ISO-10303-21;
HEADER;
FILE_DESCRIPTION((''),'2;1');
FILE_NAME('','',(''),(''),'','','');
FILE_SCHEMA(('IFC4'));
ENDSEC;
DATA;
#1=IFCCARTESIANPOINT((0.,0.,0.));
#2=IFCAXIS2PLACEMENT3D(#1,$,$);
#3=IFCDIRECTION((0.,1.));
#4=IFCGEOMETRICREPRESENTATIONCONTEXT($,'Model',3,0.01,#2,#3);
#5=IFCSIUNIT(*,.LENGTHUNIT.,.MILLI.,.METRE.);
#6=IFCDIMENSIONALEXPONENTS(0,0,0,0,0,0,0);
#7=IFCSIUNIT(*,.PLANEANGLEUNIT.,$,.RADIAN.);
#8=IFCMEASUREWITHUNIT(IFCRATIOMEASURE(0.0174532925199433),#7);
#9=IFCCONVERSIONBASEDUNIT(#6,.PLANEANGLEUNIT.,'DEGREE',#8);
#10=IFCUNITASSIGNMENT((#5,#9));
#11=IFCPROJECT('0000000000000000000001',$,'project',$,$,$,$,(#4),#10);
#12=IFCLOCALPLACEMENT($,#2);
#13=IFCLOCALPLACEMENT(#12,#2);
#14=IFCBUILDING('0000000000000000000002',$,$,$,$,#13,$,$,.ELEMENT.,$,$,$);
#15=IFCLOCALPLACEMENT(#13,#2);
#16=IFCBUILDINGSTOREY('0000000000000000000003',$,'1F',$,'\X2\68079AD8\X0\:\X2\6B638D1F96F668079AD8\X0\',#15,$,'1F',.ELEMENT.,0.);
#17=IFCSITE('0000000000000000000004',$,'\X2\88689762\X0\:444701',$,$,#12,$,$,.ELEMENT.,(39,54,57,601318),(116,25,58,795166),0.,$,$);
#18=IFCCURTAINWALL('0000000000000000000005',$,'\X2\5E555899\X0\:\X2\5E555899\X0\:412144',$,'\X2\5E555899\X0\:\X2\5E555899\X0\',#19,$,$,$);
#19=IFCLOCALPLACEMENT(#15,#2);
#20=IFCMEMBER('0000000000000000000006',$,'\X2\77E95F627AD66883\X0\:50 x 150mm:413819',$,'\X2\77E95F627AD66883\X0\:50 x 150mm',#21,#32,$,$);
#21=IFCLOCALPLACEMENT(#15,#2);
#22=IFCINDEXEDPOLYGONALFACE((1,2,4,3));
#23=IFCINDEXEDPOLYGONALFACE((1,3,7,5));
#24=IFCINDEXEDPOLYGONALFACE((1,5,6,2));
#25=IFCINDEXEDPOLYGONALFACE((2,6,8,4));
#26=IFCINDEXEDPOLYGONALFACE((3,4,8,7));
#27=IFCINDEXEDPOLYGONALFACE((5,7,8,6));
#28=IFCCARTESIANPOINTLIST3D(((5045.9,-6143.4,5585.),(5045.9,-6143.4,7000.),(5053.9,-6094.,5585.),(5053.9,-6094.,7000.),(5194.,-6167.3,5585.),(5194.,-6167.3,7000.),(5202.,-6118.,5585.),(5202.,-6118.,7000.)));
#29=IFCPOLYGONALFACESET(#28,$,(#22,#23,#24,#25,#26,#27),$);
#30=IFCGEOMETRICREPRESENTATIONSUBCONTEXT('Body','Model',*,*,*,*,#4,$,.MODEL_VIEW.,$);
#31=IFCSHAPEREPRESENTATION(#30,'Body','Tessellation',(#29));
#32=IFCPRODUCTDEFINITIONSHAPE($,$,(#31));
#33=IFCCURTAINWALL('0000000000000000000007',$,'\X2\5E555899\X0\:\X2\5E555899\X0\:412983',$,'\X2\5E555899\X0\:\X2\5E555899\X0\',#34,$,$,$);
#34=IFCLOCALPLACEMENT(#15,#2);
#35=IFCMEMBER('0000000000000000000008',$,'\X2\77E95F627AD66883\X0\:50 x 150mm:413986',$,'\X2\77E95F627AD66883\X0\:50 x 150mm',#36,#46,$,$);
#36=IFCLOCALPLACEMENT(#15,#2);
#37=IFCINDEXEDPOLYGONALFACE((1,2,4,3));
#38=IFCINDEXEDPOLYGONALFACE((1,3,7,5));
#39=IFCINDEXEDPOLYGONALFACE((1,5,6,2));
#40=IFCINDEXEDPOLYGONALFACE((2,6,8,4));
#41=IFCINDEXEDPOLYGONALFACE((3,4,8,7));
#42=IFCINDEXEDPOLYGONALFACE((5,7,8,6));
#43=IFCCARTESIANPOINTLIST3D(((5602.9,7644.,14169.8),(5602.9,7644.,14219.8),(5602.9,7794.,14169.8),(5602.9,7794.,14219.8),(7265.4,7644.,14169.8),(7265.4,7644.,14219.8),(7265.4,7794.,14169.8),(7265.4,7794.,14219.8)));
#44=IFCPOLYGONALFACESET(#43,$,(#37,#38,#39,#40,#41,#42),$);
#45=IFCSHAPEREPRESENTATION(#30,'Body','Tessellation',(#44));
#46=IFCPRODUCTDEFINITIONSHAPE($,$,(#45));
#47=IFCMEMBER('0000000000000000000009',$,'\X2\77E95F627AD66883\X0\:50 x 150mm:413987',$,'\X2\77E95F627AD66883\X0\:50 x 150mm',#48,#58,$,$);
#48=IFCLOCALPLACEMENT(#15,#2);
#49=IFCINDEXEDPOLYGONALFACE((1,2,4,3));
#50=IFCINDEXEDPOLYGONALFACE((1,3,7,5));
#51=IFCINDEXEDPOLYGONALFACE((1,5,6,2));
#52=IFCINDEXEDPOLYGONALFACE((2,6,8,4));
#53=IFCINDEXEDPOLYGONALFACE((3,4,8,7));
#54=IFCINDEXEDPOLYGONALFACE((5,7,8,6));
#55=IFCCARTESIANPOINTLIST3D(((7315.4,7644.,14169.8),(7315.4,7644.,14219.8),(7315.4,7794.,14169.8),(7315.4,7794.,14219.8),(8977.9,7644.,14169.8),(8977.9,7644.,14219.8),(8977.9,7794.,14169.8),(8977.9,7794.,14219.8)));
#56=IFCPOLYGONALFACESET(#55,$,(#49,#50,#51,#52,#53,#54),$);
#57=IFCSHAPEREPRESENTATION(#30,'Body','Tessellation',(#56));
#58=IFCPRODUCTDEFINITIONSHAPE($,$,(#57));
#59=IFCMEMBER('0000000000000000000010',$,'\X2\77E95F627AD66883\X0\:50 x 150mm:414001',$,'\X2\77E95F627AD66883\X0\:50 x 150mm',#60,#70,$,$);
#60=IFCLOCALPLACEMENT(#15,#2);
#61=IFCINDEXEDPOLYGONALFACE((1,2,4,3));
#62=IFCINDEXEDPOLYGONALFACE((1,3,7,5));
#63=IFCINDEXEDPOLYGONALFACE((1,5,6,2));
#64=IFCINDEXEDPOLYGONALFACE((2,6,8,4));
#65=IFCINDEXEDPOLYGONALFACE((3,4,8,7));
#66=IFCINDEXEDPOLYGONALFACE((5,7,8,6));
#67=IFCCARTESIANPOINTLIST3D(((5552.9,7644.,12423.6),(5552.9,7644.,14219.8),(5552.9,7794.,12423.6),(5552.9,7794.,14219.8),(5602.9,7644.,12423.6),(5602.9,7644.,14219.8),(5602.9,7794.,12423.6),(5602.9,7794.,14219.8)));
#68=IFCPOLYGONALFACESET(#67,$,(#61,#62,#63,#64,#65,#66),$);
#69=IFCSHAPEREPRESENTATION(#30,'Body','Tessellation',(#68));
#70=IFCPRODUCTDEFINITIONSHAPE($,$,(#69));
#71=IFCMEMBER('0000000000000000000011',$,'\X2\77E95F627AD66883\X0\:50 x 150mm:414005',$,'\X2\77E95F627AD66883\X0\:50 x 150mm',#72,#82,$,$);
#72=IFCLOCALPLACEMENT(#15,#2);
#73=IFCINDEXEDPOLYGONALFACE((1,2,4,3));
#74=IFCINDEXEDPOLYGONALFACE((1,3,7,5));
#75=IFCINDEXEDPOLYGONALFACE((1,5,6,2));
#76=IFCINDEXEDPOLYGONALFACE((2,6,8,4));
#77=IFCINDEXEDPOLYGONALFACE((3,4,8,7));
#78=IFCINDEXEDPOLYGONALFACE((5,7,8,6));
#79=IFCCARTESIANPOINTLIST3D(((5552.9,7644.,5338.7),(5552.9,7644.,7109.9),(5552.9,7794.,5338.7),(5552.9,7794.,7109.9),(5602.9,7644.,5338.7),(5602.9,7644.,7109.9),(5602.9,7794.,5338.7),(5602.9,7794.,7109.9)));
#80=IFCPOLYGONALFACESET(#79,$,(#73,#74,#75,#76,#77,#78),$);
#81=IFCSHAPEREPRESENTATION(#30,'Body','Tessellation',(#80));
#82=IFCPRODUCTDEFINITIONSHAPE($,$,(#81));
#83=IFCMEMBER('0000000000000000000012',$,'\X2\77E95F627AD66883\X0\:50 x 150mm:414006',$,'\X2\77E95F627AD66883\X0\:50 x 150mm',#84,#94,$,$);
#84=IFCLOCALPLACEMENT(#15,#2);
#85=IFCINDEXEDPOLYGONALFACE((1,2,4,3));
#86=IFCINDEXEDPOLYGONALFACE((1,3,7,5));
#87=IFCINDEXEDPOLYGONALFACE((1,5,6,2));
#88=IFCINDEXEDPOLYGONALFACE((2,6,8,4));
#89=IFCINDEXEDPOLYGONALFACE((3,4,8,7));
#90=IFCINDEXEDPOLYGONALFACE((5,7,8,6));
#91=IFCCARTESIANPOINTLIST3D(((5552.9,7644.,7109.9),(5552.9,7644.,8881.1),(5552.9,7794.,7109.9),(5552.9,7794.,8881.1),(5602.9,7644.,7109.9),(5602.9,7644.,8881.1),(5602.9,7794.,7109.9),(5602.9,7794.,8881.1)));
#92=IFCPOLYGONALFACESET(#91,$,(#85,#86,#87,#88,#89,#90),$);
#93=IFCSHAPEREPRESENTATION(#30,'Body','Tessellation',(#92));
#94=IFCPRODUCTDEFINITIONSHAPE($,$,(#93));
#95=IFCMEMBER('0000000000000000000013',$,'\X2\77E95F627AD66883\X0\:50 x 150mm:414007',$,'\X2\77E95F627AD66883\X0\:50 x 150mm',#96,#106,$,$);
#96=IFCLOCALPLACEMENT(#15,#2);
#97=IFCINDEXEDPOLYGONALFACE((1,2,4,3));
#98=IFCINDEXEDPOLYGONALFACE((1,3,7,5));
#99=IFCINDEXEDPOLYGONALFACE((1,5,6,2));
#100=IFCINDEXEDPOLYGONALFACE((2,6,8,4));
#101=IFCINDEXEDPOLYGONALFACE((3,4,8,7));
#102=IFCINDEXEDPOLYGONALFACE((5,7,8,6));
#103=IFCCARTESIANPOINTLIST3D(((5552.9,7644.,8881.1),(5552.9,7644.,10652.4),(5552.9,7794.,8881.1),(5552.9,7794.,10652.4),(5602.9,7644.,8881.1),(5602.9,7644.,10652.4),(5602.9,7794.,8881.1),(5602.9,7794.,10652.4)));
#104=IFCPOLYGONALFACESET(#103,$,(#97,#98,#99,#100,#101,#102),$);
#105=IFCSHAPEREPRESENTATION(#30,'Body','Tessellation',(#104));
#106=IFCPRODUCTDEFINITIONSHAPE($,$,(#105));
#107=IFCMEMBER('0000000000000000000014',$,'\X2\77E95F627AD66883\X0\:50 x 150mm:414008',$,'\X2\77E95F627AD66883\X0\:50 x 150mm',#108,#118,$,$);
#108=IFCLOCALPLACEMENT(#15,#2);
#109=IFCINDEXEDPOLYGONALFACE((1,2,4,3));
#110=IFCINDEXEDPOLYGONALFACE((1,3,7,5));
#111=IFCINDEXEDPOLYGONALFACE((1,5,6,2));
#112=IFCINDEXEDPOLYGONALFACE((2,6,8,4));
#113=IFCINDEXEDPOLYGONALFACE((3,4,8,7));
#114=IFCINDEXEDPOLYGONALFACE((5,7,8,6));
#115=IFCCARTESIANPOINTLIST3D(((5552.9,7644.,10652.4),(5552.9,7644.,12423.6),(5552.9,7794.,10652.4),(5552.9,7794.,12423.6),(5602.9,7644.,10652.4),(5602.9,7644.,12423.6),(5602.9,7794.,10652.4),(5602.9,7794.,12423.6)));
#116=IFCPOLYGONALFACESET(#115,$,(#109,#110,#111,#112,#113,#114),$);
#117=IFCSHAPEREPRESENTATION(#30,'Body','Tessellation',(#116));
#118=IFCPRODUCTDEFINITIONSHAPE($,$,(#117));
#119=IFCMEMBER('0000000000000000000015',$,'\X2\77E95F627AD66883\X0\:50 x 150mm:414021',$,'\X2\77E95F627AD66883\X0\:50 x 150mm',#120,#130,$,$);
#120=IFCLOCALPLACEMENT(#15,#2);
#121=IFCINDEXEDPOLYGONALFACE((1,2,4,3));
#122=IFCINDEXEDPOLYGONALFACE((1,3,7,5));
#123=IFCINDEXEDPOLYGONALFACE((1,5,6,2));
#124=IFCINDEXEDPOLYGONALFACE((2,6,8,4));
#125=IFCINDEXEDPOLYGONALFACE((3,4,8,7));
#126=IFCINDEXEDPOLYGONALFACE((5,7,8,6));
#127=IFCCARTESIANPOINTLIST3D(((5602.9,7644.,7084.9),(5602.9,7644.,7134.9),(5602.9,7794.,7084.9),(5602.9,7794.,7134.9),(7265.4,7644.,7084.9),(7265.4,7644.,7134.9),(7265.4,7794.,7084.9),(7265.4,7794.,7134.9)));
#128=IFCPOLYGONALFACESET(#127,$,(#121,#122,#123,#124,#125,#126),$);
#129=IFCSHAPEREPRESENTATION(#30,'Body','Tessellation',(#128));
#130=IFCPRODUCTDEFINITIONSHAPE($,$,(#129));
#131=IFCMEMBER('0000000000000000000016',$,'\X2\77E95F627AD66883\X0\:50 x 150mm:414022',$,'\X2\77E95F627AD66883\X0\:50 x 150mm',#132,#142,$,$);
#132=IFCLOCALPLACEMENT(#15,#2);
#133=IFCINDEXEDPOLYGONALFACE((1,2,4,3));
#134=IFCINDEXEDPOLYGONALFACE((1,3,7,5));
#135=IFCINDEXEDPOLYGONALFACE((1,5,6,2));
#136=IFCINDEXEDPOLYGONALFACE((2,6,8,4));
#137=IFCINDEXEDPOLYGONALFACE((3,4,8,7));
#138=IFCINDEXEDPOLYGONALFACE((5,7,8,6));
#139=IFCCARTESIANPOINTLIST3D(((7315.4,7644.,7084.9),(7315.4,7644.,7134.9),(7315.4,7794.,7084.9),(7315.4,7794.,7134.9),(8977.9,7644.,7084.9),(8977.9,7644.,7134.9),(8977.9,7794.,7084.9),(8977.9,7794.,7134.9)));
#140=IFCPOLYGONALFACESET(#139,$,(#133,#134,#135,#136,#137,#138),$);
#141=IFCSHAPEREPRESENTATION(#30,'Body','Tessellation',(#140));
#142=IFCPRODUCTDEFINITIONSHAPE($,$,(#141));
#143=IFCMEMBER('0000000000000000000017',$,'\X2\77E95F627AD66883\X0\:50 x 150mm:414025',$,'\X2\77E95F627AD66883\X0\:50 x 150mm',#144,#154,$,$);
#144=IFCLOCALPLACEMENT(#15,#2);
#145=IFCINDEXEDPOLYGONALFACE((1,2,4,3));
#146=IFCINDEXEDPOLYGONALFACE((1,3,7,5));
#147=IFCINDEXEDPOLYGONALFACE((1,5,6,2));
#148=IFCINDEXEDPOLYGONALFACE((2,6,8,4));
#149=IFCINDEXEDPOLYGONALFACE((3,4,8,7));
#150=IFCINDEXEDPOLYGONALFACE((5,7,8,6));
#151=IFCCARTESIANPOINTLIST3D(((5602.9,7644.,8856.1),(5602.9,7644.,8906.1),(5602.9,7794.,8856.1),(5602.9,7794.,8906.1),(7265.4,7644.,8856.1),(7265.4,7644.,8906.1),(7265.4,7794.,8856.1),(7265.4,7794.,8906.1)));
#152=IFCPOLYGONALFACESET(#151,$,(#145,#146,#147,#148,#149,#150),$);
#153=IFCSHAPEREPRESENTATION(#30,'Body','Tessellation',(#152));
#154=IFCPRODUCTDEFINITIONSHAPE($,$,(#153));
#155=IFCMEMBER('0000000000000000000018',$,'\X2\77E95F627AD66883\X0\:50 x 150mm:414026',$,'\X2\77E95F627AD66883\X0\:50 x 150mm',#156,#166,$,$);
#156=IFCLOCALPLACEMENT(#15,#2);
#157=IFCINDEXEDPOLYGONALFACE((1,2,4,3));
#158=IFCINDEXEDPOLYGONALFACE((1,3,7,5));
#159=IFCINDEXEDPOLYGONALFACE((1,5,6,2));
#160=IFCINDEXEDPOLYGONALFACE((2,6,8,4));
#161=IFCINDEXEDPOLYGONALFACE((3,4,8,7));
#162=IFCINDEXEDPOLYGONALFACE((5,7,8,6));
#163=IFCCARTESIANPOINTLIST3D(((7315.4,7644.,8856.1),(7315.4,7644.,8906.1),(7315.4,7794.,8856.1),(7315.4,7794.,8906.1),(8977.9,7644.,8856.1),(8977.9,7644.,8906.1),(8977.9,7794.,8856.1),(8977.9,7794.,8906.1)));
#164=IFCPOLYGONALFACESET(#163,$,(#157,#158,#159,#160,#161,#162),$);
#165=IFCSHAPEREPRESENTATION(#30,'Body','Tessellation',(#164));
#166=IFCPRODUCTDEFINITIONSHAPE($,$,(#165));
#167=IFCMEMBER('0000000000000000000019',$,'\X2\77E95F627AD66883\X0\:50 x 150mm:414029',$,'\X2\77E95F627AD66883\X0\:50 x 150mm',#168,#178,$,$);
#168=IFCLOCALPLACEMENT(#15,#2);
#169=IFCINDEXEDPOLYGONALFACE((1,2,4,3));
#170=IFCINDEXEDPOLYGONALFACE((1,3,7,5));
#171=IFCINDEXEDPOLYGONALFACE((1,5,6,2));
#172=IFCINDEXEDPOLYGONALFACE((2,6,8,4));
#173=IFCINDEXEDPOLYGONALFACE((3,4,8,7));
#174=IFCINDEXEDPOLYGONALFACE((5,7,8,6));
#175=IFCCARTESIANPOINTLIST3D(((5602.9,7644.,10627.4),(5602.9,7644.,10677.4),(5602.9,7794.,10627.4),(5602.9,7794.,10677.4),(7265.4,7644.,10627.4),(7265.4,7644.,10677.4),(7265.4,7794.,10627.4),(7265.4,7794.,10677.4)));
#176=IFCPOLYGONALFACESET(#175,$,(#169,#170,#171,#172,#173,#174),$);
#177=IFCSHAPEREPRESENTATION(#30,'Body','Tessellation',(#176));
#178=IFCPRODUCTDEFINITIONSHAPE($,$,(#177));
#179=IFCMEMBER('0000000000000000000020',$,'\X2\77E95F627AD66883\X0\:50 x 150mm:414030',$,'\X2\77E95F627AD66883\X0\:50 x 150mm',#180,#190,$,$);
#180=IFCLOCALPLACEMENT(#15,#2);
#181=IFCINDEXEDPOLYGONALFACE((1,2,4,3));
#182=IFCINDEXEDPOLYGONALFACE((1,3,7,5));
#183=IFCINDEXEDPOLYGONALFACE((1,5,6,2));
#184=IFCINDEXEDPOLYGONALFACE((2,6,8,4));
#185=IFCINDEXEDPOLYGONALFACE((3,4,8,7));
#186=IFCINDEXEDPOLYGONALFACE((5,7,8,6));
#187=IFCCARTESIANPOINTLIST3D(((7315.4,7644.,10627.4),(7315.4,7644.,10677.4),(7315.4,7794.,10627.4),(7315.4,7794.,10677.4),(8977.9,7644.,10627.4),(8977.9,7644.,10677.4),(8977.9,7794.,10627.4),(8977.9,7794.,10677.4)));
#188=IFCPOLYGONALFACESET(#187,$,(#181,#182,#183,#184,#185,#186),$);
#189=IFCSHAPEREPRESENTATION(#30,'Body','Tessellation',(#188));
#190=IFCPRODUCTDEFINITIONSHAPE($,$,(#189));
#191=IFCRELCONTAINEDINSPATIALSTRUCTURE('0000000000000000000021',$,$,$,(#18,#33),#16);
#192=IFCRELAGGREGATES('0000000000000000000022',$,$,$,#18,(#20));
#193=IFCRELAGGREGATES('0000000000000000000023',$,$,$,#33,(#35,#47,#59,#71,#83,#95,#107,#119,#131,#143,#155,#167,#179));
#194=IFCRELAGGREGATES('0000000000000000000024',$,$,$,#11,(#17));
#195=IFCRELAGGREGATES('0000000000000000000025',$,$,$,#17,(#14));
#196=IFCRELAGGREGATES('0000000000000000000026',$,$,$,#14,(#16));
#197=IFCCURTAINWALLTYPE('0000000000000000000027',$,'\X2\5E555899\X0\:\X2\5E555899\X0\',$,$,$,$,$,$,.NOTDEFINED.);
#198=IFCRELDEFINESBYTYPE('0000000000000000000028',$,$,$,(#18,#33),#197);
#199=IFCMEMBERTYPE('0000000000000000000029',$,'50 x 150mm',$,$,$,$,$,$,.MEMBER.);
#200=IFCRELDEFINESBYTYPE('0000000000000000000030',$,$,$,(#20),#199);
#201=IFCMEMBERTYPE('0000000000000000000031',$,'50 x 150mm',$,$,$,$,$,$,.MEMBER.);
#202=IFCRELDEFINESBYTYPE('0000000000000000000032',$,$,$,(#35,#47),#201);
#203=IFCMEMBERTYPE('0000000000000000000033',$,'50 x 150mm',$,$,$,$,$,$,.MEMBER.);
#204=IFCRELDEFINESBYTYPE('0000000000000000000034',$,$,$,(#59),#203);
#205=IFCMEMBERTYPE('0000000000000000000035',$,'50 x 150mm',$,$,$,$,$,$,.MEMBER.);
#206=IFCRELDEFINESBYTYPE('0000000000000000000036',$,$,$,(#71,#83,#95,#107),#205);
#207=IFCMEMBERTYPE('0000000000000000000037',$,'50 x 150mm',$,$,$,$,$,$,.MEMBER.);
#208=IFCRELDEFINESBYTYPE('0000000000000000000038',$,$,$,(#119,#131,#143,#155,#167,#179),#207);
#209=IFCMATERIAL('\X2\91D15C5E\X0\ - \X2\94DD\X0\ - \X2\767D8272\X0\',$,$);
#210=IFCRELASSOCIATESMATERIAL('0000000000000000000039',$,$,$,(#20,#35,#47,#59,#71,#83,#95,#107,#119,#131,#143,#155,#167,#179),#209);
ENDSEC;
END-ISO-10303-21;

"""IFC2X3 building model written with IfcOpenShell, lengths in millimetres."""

from ifc_helpers import new_model, entity, si_unit, converted_unit, direction, frame, origin, origin_2d_with_axis, place, context, subcontext, project, spatial, rectangle, extrude, source, transform, mapped, material, type_object, type_shapes, element, aggregate, save


model = new_model("IFC2X3")

# Units and contexts
model_context = context("Model", 3, precision=0.01, world=origin(), true_north=direction((0.0, 1.0)))
body_context = subcontext(model_context, "Body", "Model", "MODEL_VIEW")
ifc_project = project(units=[si_unit("LENGTHUNIT", "METRE", prefix="MILLI"), converted_unit("PLANEANGLEUNIT", "DEGREE", entity("IfcRatioMeasure", 0.0174532925199433), si_unit("PLANEANGLEUNIT", "RADIAN"), dimensions=[0, 0, 0, 0, 0, 0, 0])], contexts=[model_context])

# Site, building, storey
site_placement = place(None, origin())
site = spatial("IfcSite", under=ifc_project, at=site_placement, Name="表面:444701", CompositionType="ELEMENT", RefLatitude=(39, 54, 57, 601318), RefLongitude=(116, 25, 58, 795166), RefElevation=0.0)
building_placement = place(site_placement, origin())
building = spatial("IfcBuilding", under=site, at=building_placement, CompositionType="ELEMENT")
storey_placement = place(building_placement, origin())
storey = spatial("IfcBuildingStorey", under=building, at=storey_placement, Name="1F", ObjectType="标高:正负零标高", LongName="1F", CompositionType="ELEMENT", Elevation=0.0)

# Curtain wall, member
curtain_wall_type = type_object("IfcCurtainWallType", Name="幕墙:幕墙", PredefinedType="NOTDEFINED")
curtain_wall_1_placement = place(storey_placement, origin())
curtain_wall_1 = element("IfcCurtainWall", 1, at=curtain_wall_1_placement, inside=storey, type_object=curtain_wall_type, Name="幕墙:幕墙:412144", ObjectType="幕墙:幕墙")
ifc_material_1 = material(Name="金属 - 铝 - 白色")
member_type_1 = type_object("IfcMemberType", Name="50 x 150mm", PredefinedType="MEMBER")
shared_shape_1 = source(origin(), body_context, "Body", "SweptSolid", [
    extrude(rectangle(XDim=150.0, YDim=50.0, at=origin_2d_with_axis()), frame((-25.0, 0.0, -1415.0), z_axis=(0.0, 0.0, 1.0), x_axis=(0.0, -1.0, 0.0)), (0.0, 0.0, 1.0), 1415.0),
])
type_shapes(member_type_1, [shared_shape_1])
member_1_placement = place(storey_placement, frame((5127.9, -6106.0, 5585.0), z_axis=(0.0, 0.0, -1.0), x_axis=(0.15966, 0.987172, 0.0)))
member_1 = element("IfcMember", 2, at=member_1_placement, type_object=member_type_1, material=ifc_material_1, Name="矩形竖梃:50 x 150mm:413819", ObjectType="矩形竖梃:50 x 150mm", context=body_context, shape_type="MappedRepresentation", body=[
    mapped(shared_shape_1, transform((0.0, 0.0, 0.0), scale=1.0)),
])
aggregate(curtain_wall_1, [member_1])

# Curtain wall, members
curtain_wall_2_placement = place(storey_placement, origin())
curtain_wall_2 = element("IfcCurtainWall", 3, at=curtain_wall_2_placement, inside=storey, type_object=curtain_wall_type, Name="幕墙:幕墙:412983", ObjectType="幕墙:幕墙")
member_type_2 = type_object("IfcMemberType", Name="50 x 150mm", PredefinedType="MEMBER")
shared_shape_2 = source(origin(), body_context, "Body", "SweptSolid", [
    extrude(rectangle(XDim=150.0, YDim=50.0, at=origin_2d_with_axis()), frame((-25.0, 0.0, -1662.5), z_axis=(0.0, 0.0, 1.0), x_axis=(0.0, -1.0, 0.0)), (0.0, 0.0, 1.0), 1662.5),
])
type_shapes(member_type_2, [shared_shape_2])
member_2_placement = place(storey_placement, frame((7265.4, 7719.0, 14219.8), z_axis=(1.0, 0.0, 0.0), x_axis=(0.0, 0.0, 1.0)))
member_2 = element("IfcMember", 4, at=member_2_placement, type_object=member_type_2, material=ifc_material_1, Name="矩形竖梃:50 x 150mm:413986", ObjectType="矩形竖梃:50 x 150mm", context=body_context, shape_type="MappedRepresentation", body=[
    mapped(shared_shape_2, transform((0.0, 0.0, 0.0), scale=1.0)),
])
member_3_placement = place(storey_placement, frame((8977.9, 7719.0, 14219.8), z_axis=(1.0, 0.0, 0.0), x_axis=(0.0, 0.0, 1.0)))
member_3 = element("IfcMember", 5, at=member_3_placement, type_object=member_type_2, material=ifc_material_1, Name="矩形竖梃:50 x 150mm:413987", ObjectType="矩形竖梃:50 x 150mm", context=body_context, shape_type="MappedRepresentation", body=[
    mapped(shared_shape_2, transform((0.0, 0.0, 0.0), scale=1.0)),
])
member_type_3 = type_object("IfcMemberType", Name="50 x 150mm", PredefinedType="MEMBER")
shared_shape_3 = source(origin(), body_context, "Body", "SweptSolid", [
    extrude(rectangle(XDim=150.0, YDim=50.0, at=origin_2d_with_axis()), frame((-25.0, 0.0, -1796.2), z_axis=(0.0, 0.0, 1.0), x_axis=(0.0, -1.0, 0.0)), (0.0, 0.0, 1.0), 1796.2),
])
type_shapes(member_type_3, [shared_shape_3])
member_4_placement = place(storey_placement, frame((5552.9, 7719.0, 14219.8), z_axis=(0.0, 0.0, 1.0), x_axis=(-1.0, 0.0, 0.0)))
member_4 = element("IfcMember", 6, at=member_4_placement, type_object=member_type_3, material=ifc_material_1, Name="矩形竖梃:50 x 150mm:414001", ObjectType="矩形竖梃:50 x 150mm", context=body_context, shape_type="MappedRepresentation", body=[
    mapped(shared_shape_3, transform((0.0, 0.0, 0.0), scale=1.0)),
])
member_type_4 = type_object("IfcMemberType", Name="50 x 150mm", PredefinedType="MEMBER")
shared_shape_4 = source(origin(), body_context, "Body", "SweptSolid", [
    extrude(rectangle(XDim=150.0, YDim=50.0, at=origin_2d_with_axis()), frame((-25.0, 0.0, -1771.2), z_axis=(0.0, 0.0, 1.0), x_axis=(0.0, -1.0, 0.0)), (0.0, 0.0, 1.0), 1771.2),
])
type_shapes(member_type_4, [shared_shape_4])
member_5_placement = place(storey_placement, frame((5552.9, 7719.0, 7109.9), z_axis=(0.0, 0.0, 1.0), x_axis=(-1.0, 0.0, 0.0)))
member_5 = element("IfcMember", 7, at=member_5_placement, type_object=member_type_4, material=ifc_material_1, Name="矩形竖梃:50 x 150mm:414005", ObjectType="矩形竖梃:50 x 150mm", context=body_context, shape_type="MappedRepresentation", body=[
    mapped(shared_shape_4, transform((0.0, 0.0, 0.0), scale=1.0)),
])
member_6_placement = place(storey_placement, frame((5552.9, 7719.0, 8881.1), z_axis=(0.0, 0.0, 1.0), x_axis=(-1.0, 0.0, 0.0)))
member_6 = element("IfcMember", 8, at=member_6_placement, type_object=member_type_4, material=ifc_material_1, Name="矩形竖梃:50 x 150mm:414006", ObjectType="矩形竖梃:50 x 150mm", context=body_context, shape_type="MappedRepresentation", body=[
    mapped(shared_shape_4, transform((0.0, 0.0, 0.0), scale=1.0)),
])
member_7_placement = place(storey_placement, frame((5552.9, 7719.0, 10652.4), z_axis=(0.0, 0.0, 1.0), x_axis=(-1.0, 0.0, 0.0)))
member_7 = element("IfcMember", 9, at=member_7_placement, type_object=member_type_4, material=ifc_material_1, Name="矩形竖梃:50 x 150mm:414007", ObjectType="矩形竖梃:50 x 150mm", context=body_context, shape_type="MappedRepresentation", body=[
    mapped(shared_shape_4, transform((0.0, 0.0, 0.0), scale=1.0)),
])
member_8_placement = place(storey_placement, frame((5552.9, 7719.0, 12423.6), z_axis=(0.0, 0.0, 1.0), x_axis=(-1.0, 0.0, 0.0)))
member_8 = element("IfcMember", 10, at=member_8_placement, type_object=member_type_4, material=ifc_material_1, Name="矩形竖梃:50 x 150mm:414008", ObjectType="矩形竖梃:50 x 150mm", context=body_context, shape_type="MappedRepresentation", body=[
    mapped(shared_shape_4, transform((0.0, 0.0, 0.0), scale=1.0)),
])
member_type_5 = type_object("IfcMemberType", Name="50 x 150mm", PredefinedType="MEMBER")
shared_shape_5 = source(origin(), body_context, "Body", "SweptSolid", [
    extrude(rectangle(XDim=150.0, YDim=50.0, at=origin_2d_with_axis()), frame((0.0, 0.0, -1662.5), z_axis=(0.0, 0.0, 1.0), x_axis=(0.0, -1.0, 0.0)), (0.0, 0.0, 1.0), 1662.5),
])
type_shapes(member_type_5, [shared_shape_5])
member_9_placement = place(storey_placement, frame((7265.4, 7719.0, 7109.9), z_axis=(1.0, 0.0, 0.0), x_axis=(0.0, 0.0, 1.0)))
member_9 = element("IfcMember", 11, at=member_9_placement, type_object=member_type_5, material=ifc_material_1, Name="矩形竖梃:50 x 150mm:414021", ObjectType="矩形竖梃:50 x 150mm", context=body_context, shape_type="MappedRepresentation", body=[
    mapped(shared_shape_5, transform((0.0, 0.0, 0.0), scale=1.0)),
])
member_10_placement = place(storey_placement, frame((8977.9, 7719.0, 7109.9), z_axis=(1.0, 0.0, 0.0), x_axis=(0.0, 0.0, 1.0)))
member_10 = element("IfcMember", 12, at=member_10_placement, type_object=member_type_5, material=ifc_material_1, Name="矩形竖梃:50 x 150mm:414022", ObjectType="矩形竖梃:50 x 150mm", context=body_context, shape_type="MappedRepresentation", body=[
    mapped(shared_shape_5, transform((0.0, 0.0, 0.0), scale=1.0)),
])
member_11_placement = place(storey_placement, frame((7265.4, 7719.0, 8881.1), z_axis=(1.0, 0.0, 0.0), x_axis=(0.0, 0.0, 1.0)))
member_11 = element("IfcMember", 13, at=member_11_placement, type_object=member_type_5, material=ifc_material_1, Name="矩形竖梃:50 x 150mm:414025", ObjectType="矩形竖梃:50 x 150mm", context=body_context, shape_type="MappedRepresentation", body=[
    mapped(shared_shape_5, transform((0.0, 0.0, 0.0), scale=1.0)),
])
member_12_placement = place(storey_placement, frame((8977.9, 7719.0, 8881.1), z_axis=(1.0, 0.0, 0.0), x_axis=(0.0, 0.0, 1.0)))
member_12 = element("IfcMember", 14, at=member_12_placement, type_object=member_type_5, material=ifc_material_1, Name="矩形竖梃:50 x 150mm:414026", ObjectType="矩形竖梃:50 x 150mm", context=body_context, shape_type="MappedRepresentation", body=[
    mapped(shared_shape_5, transform((0.0, 0.0, 0.0), scale=1.0)),
])
member_13_placement = place(storey_placement, frame((7265.4, 7719.0, 10652.4), z_axis=(1.0, 0.0, 0.0), x_axis=(0.0, 0.0, 1.0)))
member_13 = element("IfcMember", 15, at=member_13_placement, type_object=member_type_5, material=ifc_material_1, Name="矩形竖梃:50 x 150mm:414029", ObjectType="矩形竖梃:50 x 150mm", context=body_context, shape_type="MappedRepresentation", body=[
    mapped(shared_shape_5, transform((0.0, 0.0, 0.0), scale=1.0)),
])
member_14_placement = place(storey_placement, frame((8977.9, 7719.0, 10652.4), z_axis=(1.0, 0.0, 0.0), x_axis=(0.0, 0.0, 1.0)))
member_14 = element("IfcMember", 16, at=member_14_placement, type_object=member_type_5, material=ifc_material_1, Name="矩形竖梃:50 x 150mm:414030", ObjectType="矩形竖梃:50 x 150mm", context=body_context, shape_type="MappedRepresentation", body=[
    mapped(shared_shape_5, transform((0.0, 0.0, 0.0), scale=1.0)),
])
aggregate(curtain_wall_2, [member_2, member_3, member_4, member_5, member_6, member_7, member_8, member_9, member_10, member_11, member_12, member_13, member_14])

save(model, "model.ifc")
